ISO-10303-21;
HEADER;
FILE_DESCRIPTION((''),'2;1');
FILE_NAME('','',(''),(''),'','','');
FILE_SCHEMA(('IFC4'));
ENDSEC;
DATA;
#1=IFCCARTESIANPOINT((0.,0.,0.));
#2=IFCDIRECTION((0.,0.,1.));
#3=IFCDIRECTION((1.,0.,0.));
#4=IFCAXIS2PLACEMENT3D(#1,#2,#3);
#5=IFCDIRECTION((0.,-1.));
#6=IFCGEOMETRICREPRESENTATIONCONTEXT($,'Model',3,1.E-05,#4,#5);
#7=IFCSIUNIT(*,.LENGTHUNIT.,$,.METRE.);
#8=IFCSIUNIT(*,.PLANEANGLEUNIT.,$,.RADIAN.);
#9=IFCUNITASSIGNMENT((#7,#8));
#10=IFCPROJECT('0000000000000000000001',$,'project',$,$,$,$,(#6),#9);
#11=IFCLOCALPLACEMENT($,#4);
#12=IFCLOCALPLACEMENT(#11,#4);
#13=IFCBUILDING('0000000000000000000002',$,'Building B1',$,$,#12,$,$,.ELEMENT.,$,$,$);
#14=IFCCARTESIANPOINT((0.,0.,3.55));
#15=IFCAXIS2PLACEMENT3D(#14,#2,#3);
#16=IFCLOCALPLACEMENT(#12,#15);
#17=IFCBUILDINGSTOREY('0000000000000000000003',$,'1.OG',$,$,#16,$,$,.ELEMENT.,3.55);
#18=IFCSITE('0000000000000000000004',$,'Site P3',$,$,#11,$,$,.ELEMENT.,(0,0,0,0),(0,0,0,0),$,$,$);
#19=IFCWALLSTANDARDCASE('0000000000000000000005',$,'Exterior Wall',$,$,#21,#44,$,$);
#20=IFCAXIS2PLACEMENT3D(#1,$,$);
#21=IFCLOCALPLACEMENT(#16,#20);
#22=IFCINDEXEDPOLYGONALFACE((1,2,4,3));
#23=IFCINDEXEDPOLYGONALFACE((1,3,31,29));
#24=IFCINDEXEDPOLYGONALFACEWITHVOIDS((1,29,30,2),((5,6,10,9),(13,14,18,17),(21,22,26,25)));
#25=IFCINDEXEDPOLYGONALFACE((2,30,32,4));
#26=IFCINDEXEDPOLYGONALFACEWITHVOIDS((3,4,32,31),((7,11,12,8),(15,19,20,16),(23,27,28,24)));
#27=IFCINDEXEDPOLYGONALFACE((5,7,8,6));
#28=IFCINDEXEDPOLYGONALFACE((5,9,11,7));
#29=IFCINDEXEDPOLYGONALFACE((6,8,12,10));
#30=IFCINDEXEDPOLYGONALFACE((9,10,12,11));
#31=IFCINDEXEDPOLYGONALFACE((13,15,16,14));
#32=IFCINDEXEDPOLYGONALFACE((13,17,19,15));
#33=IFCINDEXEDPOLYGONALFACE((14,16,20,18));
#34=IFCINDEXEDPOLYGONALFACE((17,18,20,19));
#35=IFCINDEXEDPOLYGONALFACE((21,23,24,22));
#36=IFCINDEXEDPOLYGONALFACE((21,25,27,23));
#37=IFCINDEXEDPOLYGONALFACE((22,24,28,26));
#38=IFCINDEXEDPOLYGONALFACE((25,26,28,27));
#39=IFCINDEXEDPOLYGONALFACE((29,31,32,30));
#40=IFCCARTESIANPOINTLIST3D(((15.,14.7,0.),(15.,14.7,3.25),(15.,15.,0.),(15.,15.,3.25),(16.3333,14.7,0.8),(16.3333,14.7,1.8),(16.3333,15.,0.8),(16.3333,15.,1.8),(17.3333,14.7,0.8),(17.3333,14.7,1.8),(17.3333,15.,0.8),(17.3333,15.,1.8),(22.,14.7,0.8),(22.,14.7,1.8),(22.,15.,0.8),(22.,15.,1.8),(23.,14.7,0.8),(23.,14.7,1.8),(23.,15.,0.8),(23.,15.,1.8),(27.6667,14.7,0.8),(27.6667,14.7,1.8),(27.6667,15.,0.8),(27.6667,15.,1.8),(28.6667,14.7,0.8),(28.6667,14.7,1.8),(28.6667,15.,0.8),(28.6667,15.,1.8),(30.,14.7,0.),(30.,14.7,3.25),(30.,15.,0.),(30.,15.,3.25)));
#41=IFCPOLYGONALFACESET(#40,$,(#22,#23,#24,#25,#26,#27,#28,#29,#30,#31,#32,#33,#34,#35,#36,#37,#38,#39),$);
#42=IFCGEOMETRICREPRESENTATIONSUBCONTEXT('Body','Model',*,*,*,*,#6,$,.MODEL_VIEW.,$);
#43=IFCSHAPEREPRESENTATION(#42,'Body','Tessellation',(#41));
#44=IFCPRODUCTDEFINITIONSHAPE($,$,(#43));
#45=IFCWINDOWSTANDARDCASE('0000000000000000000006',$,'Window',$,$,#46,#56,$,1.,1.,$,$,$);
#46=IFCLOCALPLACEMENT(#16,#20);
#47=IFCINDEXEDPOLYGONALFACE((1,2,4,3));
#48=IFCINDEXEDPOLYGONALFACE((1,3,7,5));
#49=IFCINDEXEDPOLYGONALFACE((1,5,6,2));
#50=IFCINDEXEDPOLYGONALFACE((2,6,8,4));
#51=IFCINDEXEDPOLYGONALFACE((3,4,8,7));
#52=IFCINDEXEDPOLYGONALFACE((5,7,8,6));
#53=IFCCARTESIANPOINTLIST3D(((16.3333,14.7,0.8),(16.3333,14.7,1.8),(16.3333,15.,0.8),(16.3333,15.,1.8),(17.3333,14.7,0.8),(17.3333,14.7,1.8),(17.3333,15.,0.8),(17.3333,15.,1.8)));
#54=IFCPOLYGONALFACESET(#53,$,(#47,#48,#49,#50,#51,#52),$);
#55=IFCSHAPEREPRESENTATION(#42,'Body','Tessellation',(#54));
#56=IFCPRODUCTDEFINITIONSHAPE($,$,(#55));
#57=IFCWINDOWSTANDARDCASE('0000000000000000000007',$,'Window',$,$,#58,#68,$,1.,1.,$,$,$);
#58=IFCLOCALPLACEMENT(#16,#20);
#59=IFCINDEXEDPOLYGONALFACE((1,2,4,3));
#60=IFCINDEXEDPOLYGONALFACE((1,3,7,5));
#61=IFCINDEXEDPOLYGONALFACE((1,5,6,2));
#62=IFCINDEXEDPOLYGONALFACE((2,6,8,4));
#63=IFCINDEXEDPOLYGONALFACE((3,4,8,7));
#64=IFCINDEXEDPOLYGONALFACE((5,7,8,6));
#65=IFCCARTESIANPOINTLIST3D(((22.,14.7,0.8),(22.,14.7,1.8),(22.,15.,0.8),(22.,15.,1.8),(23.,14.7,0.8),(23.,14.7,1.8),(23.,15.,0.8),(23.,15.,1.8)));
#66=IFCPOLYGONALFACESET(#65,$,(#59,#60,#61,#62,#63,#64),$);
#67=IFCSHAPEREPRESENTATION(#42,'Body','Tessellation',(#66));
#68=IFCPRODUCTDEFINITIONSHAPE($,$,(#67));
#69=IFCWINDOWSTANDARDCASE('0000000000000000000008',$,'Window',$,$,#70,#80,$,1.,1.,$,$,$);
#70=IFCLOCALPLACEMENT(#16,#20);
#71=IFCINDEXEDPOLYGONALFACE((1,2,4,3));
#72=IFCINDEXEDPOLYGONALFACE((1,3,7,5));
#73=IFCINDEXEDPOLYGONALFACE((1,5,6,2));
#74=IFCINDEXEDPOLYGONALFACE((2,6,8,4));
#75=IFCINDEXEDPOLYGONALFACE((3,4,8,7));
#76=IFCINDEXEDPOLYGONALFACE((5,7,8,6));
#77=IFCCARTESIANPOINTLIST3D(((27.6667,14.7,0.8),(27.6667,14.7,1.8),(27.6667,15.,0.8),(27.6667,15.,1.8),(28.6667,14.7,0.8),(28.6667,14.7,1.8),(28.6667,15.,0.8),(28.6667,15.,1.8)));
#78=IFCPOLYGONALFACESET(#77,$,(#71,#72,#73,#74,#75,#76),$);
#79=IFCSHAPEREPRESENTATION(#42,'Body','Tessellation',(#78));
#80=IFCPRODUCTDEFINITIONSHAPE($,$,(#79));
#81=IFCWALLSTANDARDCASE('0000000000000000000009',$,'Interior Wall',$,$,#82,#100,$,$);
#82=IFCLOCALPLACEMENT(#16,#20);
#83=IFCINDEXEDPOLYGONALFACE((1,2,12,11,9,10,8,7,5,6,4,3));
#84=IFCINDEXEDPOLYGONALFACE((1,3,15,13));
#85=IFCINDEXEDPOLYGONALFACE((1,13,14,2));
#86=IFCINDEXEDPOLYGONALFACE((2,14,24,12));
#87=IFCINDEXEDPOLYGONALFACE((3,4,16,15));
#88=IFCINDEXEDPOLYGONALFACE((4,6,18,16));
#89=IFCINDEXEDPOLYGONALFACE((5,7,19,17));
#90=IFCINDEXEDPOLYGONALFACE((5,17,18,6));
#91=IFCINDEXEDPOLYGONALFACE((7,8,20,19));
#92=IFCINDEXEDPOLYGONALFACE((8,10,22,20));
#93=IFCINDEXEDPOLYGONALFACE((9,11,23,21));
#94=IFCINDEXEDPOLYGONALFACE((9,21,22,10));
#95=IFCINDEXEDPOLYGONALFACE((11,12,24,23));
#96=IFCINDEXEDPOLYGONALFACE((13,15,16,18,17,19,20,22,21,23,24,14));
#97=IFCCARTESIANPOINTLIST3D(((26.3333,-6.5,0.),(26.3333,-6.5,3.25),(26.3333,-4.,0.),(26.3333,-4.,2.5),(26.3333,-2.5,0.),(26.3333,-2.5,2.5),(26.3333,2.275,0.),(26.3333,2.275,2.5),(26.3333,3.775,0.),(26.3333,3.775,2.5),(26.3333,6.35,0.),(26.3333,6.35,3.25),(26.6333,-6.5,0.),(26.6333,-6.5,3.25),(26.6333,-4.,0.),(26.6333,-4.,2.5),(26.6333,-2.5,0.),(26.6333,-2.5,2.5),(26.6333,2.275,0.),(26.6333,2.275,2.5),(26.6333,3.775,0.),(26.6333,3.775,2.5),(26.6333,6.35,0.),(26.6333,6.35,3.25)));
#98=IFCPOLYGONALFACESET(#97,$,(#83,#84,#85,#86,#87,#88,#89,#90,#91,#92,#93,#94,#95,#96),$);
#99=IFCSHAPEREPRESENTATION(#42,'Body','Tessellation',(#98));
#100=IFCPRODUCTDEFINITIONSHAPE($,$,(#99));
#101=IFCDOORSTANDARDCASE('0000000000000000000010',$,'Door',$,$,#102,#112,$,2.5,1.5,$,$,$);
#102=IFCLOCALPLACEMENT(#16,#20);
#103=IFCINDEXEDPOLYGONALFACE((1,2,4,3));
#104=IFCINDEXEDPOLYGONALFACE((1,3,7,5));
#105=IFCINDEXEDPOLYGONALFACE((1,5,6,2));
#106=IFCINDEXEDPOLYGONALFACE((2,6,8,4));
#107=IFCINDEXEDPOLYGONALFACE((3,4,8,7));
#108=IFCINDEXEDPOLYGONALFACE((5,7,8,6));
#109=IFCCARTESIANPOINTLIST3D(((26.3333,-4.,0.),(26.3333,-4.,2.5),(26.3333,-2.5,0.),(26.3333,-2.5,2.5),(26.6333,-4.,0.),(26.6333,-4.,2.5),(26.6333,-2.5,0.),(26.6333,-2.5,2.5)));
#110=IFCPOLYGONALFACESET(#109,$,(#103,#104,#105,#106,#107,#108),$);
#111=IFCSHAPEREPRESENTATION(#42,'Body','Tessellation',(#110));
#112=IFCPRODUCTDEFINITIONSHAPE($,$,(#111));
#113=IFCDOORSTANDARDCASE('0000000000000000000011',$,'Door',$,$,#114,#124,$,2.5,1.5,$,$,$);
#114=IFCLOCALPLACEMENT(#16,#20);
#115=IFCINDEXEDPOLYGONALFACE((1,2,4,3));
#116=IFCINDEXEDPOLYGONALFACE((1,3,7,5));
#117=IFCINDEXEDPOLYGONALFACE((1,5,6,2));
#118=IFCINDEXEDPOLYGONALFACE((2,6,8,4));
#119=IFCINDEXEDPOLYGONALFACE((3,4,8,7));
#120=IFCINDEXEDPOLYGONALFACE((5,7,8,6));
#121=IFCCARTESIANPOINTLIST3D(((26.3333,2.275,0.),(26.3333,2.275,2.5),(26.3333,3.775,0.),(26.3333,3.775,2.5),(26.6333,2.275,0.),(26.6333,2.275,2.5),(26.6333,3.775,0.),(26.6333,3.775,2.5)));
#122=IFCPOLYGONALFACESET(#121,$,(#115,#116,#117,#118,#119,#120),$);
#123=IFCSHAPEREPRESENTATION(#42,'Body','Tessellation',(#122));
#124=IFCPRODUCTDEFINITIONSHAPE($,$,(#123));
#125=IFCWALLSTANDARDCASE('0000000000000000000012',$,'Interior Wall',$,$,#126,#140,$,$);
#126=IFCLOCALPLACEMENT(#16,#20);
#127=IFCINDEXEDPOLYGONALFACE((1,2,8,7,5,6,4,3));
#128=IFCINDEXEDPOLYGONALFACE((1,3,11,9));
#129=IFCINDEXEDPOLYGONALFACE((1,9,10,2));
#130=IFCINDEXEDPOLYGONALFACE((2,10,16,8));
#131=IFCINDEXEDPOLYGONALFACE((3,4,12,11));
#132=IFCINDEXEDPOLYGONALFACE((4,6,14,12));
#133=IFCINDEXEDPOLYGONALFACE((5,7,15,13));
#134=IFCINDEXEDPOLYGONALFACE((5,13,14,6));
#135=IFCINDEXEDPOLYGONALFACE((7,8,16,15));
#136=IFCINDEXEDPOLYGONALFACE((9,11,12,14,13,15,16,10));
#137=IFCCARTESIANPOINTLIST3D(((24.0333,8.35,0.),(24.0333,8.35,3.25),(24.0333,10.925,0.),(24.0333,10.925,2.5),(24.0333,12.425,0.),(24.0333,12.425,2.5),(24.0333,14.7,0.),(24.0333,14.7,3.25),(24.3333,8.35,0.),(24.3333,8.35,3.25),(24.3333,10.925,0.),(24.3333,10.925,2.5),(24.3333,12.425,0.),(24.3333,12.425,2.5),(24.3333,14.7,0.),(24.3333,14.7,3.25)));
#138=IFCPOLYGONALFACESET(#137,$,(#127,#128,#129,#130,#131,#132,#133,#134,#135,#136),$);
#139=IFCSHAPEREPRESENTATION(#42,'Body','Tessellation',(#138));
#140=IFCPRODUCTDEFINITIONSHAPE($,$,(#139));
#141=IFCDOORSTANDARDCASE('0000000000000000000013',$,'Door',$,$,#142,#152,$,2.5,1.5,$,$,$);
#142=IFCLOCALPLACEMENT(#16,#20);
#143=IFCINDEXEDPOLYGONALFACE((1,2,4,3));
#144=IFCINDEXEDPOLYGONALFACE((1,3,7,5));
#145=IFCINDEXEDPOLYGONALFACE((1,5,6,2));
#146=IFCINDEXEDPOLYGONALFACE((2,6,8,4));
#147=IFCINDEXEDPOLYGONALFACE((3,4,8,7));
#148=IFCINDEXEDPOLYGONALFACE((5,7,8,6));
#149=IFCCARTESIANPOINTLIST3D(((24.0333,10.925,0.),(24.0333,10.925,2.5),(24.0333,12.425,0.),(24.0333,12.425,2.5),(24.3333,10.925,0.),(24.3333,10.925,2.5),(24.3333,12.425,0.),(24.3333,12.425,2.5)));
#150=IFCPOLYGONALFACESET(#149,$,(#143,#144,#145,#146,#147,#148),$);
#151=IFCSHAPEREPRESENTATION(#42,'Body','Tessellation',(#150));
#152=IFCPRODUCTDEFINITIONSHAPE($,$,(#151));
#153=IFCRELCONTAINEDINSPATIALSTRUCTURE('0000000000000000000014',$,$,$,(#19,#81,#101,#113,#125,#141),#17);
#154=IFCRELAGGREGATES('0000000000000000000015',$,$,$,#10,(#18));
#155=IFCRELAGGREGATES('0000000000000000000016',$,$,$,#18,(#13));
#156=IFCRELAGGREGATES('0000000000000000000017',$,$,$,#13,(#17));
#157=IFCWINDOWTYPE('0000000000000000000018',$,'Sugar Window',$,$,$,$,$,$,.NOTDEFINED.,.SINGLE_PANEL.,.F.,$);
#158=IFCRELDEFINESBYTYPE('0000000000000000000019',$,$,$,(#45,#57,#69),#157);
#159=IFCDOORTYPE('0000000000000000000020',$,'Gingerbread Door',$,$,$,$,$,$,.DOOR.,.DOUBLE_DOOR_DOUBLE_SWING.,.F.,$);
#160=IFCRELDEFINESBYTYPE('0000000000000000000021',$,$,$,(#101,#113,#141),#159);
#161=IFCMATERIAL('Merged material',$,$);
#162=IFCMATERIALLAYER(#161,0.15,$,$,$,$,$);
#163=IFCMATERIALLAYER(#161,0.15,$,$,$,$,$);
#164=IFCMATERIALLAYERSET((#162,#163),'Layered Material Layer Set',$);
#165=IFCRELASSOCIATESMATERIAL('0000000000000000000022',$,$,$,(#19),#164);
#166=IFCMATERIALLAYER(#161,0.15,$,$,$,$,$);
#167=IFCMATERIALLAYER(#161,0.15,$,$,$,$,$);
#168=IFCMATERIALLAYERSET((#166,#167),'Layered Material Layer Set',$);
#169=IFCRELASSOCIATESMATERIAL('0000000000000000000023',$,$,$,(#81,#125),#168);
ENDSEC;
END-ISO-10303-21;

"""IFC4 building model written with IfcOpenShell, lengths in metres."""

from ifc_helpers import new_model, si_unit, direction, frame, origin_with_axes, place, context, subcontext, project, spatial, polyline, outline, extrude, source, transform, mapped, material, layer, layer_set, layer_usage, type_object, element, fill, save


model = new_model("IFC4")

# Units and contexts
model_context = context("Model", 3, precision=1e-05, world=origin_with_axes(), true_north=direction((0.0, -1.0)))
body_context = subcontext(model_context, "Body", "Model", "MODEL_VIEW")
ifc_project = project(units=[si_unit("LENGTHUNIT", "METRE"), si_unit("PLANEANGLEUNIT", "RADIAN")], contexts=[model_context])

# Site, building, storey
site_placement = place(None, origin_with_axes())
site = spatial("IfcSite", under=ifc_project, at=site_placement, Name="Site P3", CompositionType="ELEMENT", RefLatitude=(0, 0, 0, 0), RefLongitude=(0, 0, 0, 0))
building_placement = place(site_placement, origin_with_axes())
building = spatial("IfcBuilding", under=site, at=building_placement, Name="Building B1", CompositionType="ELEMENT")
storey_placement = place(building_placement, frame((0.0, 0.0, 3.55), z_axis=(0.0, 0.0, 1.0), x_axis=(1.0, 0.0, 0.0)))
storey = spatial("IfcBuildingStorey", under=building, at=storey_placement, Name="1.OG", CompositionType="ELEMENT", Elevation=3.55)

# Wall, openings, windows
ifc_material = material(Name="Merged material")
ifc_layer_1 = layer(ifc_material, 0.15)
ifc_layer_2 = layer(ifc_material, 0.15)
ifc_layer_set_1 = layer_set([ifc_layer_1, ifc_layer_2], Name="Layered Material Layer Set")
ifc_layer_usage_1 = layer_usage(ifc_layer_set_1, "AXIS2", "POSITIVE", -0.15)
wall_1_placement = place(storey_placement, frame((30.0, 14.85, 0.0), z_axis=(0.0, 0.0, 1.0), x_axis=(-1.0, 0.0, 0.0)))
wall_1 = element("IfcWallStandardCase", 1, at=wall_1_placement, inside=storey, material=ifc_layer_usage_1, Name="Exterior Wall", context=body_context, shape_type="SweptSolid", body=[
    extrude(outline(polyline([(0.0, 0.15), (15.0, 0.15), (15.0, -0.15), (0.0, -0.15), (0.0, 0.15)])), origin_with_axes(), (0.0, 0.0, 1.0), 3.25),
])
opening_1_placement = place(wall_1_placement, frame((12.6667, 0.0, 0.8), z_axis=(0.0, 0.0, 1.0), x_axis=(1.0, 0.0, 0.0)))
opening_1 = element("IfcOpeningStandardCase", 2, at=opening_1_placement, cuts=wall_1, context=body_context, shape_type="SweptSolid", body=[
    extrude(outline(polyline([(0.0, 0.0), (0.0, 1.0), (1.0, 1.0), (1.0, 0.0), (0.0, 0.0)])), frame((0.0, -0.15, 0.0), z_axis=(0.0, 1.0, 0.0), x_axis=(0.0, 0.0, 1.0)), (0.0, 0.0, 1.0), 0.3),
])
opening_2_placement = place(wall_1_placement, frame((7.0, 0.0, 0.8), z_axis=(0.0, 0.0, 1.0), x_axis=(1.0, 0.0, 0.0)))
opening_2 = element("IfcOpeningStandardCase", 3, at=opening_2_placement, cuts=wall_1, context=body_context, shape_type="SweptSolid", body=[
    extrude(outline(polyline([(0.0, 0.0), (0.0, 1.0), (1.0, 1.0), (1.0, 0.0), (0.0, 0.0)])), frame((0.0, -0.15, 0.0), z_axis=(0.0, 1.0, 0.0), x_axis=(0.0, 0.0, 1.0)), (0.0, 0.0, 1.0), 0.3),
])
opening_3_placement = place(wall_1_placement, frame((1.3333, 0.0, 0.8), z_axis=(0.0, 0.0, 1.0), x_axis=(1.0, 0.0, 0.0)))
opening_3 = element("IfcOpeningStandardCase", 4, at=opening_3_placement, cuts=wall_1, context=body_context, shape_type="SweptSolid", body=[
    extrude(outline(polyline([(0.0, 0.0), (0.0, 1.0), (1.0, 1.0), (1.0, 0.0), (0.0, 0.0)])), frame((0.0, -0.15, 0.0), z_axis=(0.0, 1.0, 0.0), x_axis=(0.0, 0.0, 1.0)), (0.0, 0.0, 1.0), 0.3),
])
window_type = type_object("IfcWindowType", Name="Sugar Window", ParameterTakesPrecedence=False, PartitioningType="SINGLE_PANEL", PredefinedType="NOTDEFINED")
shared_shape_1 = source(origin_with_axes(), body_context, "Body", "SweptSolid", [
    extrude(outline(polyline([(0.0, 0.0), (0.0, 1.0), (1.0, 1.0), (1.0, 0.0), (0.0, 0.0)])), frame((0.0, -0.15, 0.0), z_axis=(0.0, 1.0, 0.0), x_axis=(0.0, 0.0, 1.0)), (0.0, 0.0, 1.0), 0.3),
])
window_1_placement = place(opening_1_placement, origin_with_axes())
window_1 = element("IfcWindowStandardCase", 5, at=window_1_placement, type_object=window_type, Name="Window", OverallHeight=1.0, OverallWidth=1.0, context=body_context, shape_type="MappedRepresentation", body=[
    mapped(shared_shape_1, transform((0.0, 0.0, 0.0))),
])
fill(opening_1, window_1)
window_2_placement = place(opening_2_placement, origin_with_axes())
window_2 = element("IfcWindowStandardCase", 6, at=window_2_placement, type_object=window_type, Name="Window", OverallHeight=1.0, OverallWidth=1.0, context=body_context, shape_type="MappedRepresentation", body=[
    mapped(shared_shape_1, transform((0.0, 0.0, 0.0))),
])
fill(opening_2, window_2)
window_3_placement = place(opening_3_placement, origin_with_axes())
window_3 = element("IfcWindowStandardCase", 7, at=window_3_placement, type_object=window_type, Name="Window", OverallHeight=1.0, OverallWidth=1.0, context=body_context, shape_type="MappedRepresentation", body=[
    mapped(shared_shape_1, transform((0.0, 0.0, 0.0))),
])
fill(opening_3, window_3)

# Wall, openings, doors
ifc_layer_3 = layer(ifc_material, 0.15)
ifc_layer_4 = layer(ifc_material, 0.15)
ifc_layer_set_2 = layer_set([ifc_layer_3, ifc_layer_4], Name="Layered Material Layer Set")
ifc_layer_usage_2 = layer_usage(ifc_layer_set_2, "AXIS2", "POSITIVE", -0.15)
wall_2_placement = place(storey_placement, frame((26.4833, 6.35, 0.0), z_axis=(0.0, 0.0, 1.0), x_axis=(0.0, -1.0, 0.0)))
wall_2 = element("IfcWallStandardCase", 8, at=wall_2_placement, inside=storey, material=ifc_layer_usage_2, Name="Interior Wall", context=body_context, shape_type="SweptSolid", body=[
    extrude(outline(polyline([(0.0, 0.15), (12.85, 0.15), (12.85, -0.15), (0.0, -0.15), (0.0, 0.15)])), origin_with_axes(), (0.0, 0.0, 1.0), 3.25),
])
opening_4_placement = place(wall_2_placement, frame((8.85, 0.0, 0.0), z_axis=(0.0, 0.0, 1.0), x_axis=(1.0, 0.0, 0.0)))
opening_4 = element("IfcOpeningStandardCase", 9, at=opening_4_placement, cuts=wall_2, context=body_context, shape_type="SweptSolid", body=[
    extrude(outline(polyline([(0.0, 0.0), (0.0, 1.5), (2.5, 1.5), (2.5, 0.0), (0.0, 0.0)])), frame((0.0, -0.15, 0.0), z_axis=(0.0, 1.0, 0.0), x_axis=(0.0, 0.0, 1.0)), (0.0, 0.0, 1.0), 0.3),
])
opening_5_placement = place(wall_2_placement, frame((2.575, 0.0, 0.0), z_axis=(0.0, 0.0, 1.0), x_axis=(1.0, 0.0, 0.0)))
opening_5 = element("IfcOpeningStandardCase", 10, at=opening_5_placement, cuts=wall_2, context=body_context, shape_type="SweptSolid", body=[
    extrude(outline(polyline([(0.0, 0.0), (0.0, 1.5), (2.5, 1.5), (2.5, 0.0), (0.0, 0.0)])), frame((0.0, -0.15, 0.0), z_axis=(0.0, 1.0, 0.0), x_axis=(0.0, 0.0, 1.0)), (0.0, 0.0, 1.0), 0.3),
])
door_type = type_object("IfcDoorType", Name="Gingerbread Door", OperationType="DOUBLE_DOOR_DOUBLE_SWING", ParameterTakesPrecedence=False, PredefinedType="DOOR")
shared_shape_2 = source(origin_with_axes(), body_context, "Body", "SweptSolid", [
    extrude(outline(polyline([(0.0, 0.0), (0.0, 1.5), (2.5, 1.5), (2.5, 0.0), (0.0, 0.0)])), frame((0.0, -0.15, 0.0), z_axis=(0.0, 1.0, 0.0), x_axis=(0.0, 0.0, 1.0)), (0.0, 0.0, 1.0), 0.3),
])
door_1_placement = place(opening_4_placement, origin_with_axes())
door_1 = element("IfcDoorStandardCase", 11, at=door_1_placement, inside=storey, type_object=door_type, Name="Door", OverallHeight=2.5, OverallWidth=1.5, context=body_context, shape_type="MappedRepresentation", body=[
    mapped(shared_shape_2, transform((0.0, 0.0, 0.0))),
])
fill(opening_4, door_1)
door_2_placement = place(opening_5_placement, origin_with_axes())
door_2 = element("IfcDoorStandardCase", 12, at=door_2_placement, inside=storey, type_object=door_type, Name="Door", OverallHeight=2.5, OverallWidth=1.5, context=body_context, shape_type="MappedRepresentation", body=[
    mapped(shared_shape_2, transform((0.0, 0.0, 0.0))),
])
fill(opening_5, door_2)

# Wall, opening, door
wall_3_placement = place(storey_placement, frame((24.1833, 14.7, 0.0), z_axis=(0.0, 0.0, 1.0), x_axis=(0.0, -1.0, 0.0)))
wall_3 = element("IfcWallStandardCase", 13, at=wall_3_placement, inside=storey, material=ifc_layer_usage_2, Name="Interior Wall", context=body_context, shape_type="SweptSolid", body=[
    extrude(outline(polyline([(0.0, 0.15), (6.35, 0.15), (6.35, -0.15), (0.0, -0.15), (0.0, 0.15)])), origin_with_axes(), (0.0, 0.0, 1.0), 3.25),
])
opening_6_placement = place(wall_3_placement, frame((2.275, 0.0, 0.0), z_axis=(0.0, 0.0, 1.0), x_axis=(1.0, 0.0, 0.0)))
opening_6 = element("IfcOpeningStandardCase", 14, at=opening_6_placement, cuts=wall_3, context=body_context, shape_type="SweptSolid", body=[
    extrude(outline(polyline([(0.0, 0.0), (0.0, 1.5), (2.5, 1.5), (2.5, 0.0), (0.0, 0.0)])), frame((0.0, -0.15, 0.0), z_axis=(0.0, 1.0, 0.0), x_axis=(0.0, 0.0, 1.0)), (0.0, 0.0, 1.0), 0.3),
])
door_3_placement = place(opening_6_placement, origin_with_axes())
door_3 = element("IfcDoorStandardCase", 15, at=door_3_placement, inside=storey, type_object=door_type, Name="Door", OverallHeight=2.5, OverallWidth=1.5, context=body_context, shape_type="MappedRepresentation", body=[
    mapped(shared_shape_2, transform((0.0, 0.0, 0.0))),
])
fill(opening_6, door_3)

save(model, "model.ifc")
